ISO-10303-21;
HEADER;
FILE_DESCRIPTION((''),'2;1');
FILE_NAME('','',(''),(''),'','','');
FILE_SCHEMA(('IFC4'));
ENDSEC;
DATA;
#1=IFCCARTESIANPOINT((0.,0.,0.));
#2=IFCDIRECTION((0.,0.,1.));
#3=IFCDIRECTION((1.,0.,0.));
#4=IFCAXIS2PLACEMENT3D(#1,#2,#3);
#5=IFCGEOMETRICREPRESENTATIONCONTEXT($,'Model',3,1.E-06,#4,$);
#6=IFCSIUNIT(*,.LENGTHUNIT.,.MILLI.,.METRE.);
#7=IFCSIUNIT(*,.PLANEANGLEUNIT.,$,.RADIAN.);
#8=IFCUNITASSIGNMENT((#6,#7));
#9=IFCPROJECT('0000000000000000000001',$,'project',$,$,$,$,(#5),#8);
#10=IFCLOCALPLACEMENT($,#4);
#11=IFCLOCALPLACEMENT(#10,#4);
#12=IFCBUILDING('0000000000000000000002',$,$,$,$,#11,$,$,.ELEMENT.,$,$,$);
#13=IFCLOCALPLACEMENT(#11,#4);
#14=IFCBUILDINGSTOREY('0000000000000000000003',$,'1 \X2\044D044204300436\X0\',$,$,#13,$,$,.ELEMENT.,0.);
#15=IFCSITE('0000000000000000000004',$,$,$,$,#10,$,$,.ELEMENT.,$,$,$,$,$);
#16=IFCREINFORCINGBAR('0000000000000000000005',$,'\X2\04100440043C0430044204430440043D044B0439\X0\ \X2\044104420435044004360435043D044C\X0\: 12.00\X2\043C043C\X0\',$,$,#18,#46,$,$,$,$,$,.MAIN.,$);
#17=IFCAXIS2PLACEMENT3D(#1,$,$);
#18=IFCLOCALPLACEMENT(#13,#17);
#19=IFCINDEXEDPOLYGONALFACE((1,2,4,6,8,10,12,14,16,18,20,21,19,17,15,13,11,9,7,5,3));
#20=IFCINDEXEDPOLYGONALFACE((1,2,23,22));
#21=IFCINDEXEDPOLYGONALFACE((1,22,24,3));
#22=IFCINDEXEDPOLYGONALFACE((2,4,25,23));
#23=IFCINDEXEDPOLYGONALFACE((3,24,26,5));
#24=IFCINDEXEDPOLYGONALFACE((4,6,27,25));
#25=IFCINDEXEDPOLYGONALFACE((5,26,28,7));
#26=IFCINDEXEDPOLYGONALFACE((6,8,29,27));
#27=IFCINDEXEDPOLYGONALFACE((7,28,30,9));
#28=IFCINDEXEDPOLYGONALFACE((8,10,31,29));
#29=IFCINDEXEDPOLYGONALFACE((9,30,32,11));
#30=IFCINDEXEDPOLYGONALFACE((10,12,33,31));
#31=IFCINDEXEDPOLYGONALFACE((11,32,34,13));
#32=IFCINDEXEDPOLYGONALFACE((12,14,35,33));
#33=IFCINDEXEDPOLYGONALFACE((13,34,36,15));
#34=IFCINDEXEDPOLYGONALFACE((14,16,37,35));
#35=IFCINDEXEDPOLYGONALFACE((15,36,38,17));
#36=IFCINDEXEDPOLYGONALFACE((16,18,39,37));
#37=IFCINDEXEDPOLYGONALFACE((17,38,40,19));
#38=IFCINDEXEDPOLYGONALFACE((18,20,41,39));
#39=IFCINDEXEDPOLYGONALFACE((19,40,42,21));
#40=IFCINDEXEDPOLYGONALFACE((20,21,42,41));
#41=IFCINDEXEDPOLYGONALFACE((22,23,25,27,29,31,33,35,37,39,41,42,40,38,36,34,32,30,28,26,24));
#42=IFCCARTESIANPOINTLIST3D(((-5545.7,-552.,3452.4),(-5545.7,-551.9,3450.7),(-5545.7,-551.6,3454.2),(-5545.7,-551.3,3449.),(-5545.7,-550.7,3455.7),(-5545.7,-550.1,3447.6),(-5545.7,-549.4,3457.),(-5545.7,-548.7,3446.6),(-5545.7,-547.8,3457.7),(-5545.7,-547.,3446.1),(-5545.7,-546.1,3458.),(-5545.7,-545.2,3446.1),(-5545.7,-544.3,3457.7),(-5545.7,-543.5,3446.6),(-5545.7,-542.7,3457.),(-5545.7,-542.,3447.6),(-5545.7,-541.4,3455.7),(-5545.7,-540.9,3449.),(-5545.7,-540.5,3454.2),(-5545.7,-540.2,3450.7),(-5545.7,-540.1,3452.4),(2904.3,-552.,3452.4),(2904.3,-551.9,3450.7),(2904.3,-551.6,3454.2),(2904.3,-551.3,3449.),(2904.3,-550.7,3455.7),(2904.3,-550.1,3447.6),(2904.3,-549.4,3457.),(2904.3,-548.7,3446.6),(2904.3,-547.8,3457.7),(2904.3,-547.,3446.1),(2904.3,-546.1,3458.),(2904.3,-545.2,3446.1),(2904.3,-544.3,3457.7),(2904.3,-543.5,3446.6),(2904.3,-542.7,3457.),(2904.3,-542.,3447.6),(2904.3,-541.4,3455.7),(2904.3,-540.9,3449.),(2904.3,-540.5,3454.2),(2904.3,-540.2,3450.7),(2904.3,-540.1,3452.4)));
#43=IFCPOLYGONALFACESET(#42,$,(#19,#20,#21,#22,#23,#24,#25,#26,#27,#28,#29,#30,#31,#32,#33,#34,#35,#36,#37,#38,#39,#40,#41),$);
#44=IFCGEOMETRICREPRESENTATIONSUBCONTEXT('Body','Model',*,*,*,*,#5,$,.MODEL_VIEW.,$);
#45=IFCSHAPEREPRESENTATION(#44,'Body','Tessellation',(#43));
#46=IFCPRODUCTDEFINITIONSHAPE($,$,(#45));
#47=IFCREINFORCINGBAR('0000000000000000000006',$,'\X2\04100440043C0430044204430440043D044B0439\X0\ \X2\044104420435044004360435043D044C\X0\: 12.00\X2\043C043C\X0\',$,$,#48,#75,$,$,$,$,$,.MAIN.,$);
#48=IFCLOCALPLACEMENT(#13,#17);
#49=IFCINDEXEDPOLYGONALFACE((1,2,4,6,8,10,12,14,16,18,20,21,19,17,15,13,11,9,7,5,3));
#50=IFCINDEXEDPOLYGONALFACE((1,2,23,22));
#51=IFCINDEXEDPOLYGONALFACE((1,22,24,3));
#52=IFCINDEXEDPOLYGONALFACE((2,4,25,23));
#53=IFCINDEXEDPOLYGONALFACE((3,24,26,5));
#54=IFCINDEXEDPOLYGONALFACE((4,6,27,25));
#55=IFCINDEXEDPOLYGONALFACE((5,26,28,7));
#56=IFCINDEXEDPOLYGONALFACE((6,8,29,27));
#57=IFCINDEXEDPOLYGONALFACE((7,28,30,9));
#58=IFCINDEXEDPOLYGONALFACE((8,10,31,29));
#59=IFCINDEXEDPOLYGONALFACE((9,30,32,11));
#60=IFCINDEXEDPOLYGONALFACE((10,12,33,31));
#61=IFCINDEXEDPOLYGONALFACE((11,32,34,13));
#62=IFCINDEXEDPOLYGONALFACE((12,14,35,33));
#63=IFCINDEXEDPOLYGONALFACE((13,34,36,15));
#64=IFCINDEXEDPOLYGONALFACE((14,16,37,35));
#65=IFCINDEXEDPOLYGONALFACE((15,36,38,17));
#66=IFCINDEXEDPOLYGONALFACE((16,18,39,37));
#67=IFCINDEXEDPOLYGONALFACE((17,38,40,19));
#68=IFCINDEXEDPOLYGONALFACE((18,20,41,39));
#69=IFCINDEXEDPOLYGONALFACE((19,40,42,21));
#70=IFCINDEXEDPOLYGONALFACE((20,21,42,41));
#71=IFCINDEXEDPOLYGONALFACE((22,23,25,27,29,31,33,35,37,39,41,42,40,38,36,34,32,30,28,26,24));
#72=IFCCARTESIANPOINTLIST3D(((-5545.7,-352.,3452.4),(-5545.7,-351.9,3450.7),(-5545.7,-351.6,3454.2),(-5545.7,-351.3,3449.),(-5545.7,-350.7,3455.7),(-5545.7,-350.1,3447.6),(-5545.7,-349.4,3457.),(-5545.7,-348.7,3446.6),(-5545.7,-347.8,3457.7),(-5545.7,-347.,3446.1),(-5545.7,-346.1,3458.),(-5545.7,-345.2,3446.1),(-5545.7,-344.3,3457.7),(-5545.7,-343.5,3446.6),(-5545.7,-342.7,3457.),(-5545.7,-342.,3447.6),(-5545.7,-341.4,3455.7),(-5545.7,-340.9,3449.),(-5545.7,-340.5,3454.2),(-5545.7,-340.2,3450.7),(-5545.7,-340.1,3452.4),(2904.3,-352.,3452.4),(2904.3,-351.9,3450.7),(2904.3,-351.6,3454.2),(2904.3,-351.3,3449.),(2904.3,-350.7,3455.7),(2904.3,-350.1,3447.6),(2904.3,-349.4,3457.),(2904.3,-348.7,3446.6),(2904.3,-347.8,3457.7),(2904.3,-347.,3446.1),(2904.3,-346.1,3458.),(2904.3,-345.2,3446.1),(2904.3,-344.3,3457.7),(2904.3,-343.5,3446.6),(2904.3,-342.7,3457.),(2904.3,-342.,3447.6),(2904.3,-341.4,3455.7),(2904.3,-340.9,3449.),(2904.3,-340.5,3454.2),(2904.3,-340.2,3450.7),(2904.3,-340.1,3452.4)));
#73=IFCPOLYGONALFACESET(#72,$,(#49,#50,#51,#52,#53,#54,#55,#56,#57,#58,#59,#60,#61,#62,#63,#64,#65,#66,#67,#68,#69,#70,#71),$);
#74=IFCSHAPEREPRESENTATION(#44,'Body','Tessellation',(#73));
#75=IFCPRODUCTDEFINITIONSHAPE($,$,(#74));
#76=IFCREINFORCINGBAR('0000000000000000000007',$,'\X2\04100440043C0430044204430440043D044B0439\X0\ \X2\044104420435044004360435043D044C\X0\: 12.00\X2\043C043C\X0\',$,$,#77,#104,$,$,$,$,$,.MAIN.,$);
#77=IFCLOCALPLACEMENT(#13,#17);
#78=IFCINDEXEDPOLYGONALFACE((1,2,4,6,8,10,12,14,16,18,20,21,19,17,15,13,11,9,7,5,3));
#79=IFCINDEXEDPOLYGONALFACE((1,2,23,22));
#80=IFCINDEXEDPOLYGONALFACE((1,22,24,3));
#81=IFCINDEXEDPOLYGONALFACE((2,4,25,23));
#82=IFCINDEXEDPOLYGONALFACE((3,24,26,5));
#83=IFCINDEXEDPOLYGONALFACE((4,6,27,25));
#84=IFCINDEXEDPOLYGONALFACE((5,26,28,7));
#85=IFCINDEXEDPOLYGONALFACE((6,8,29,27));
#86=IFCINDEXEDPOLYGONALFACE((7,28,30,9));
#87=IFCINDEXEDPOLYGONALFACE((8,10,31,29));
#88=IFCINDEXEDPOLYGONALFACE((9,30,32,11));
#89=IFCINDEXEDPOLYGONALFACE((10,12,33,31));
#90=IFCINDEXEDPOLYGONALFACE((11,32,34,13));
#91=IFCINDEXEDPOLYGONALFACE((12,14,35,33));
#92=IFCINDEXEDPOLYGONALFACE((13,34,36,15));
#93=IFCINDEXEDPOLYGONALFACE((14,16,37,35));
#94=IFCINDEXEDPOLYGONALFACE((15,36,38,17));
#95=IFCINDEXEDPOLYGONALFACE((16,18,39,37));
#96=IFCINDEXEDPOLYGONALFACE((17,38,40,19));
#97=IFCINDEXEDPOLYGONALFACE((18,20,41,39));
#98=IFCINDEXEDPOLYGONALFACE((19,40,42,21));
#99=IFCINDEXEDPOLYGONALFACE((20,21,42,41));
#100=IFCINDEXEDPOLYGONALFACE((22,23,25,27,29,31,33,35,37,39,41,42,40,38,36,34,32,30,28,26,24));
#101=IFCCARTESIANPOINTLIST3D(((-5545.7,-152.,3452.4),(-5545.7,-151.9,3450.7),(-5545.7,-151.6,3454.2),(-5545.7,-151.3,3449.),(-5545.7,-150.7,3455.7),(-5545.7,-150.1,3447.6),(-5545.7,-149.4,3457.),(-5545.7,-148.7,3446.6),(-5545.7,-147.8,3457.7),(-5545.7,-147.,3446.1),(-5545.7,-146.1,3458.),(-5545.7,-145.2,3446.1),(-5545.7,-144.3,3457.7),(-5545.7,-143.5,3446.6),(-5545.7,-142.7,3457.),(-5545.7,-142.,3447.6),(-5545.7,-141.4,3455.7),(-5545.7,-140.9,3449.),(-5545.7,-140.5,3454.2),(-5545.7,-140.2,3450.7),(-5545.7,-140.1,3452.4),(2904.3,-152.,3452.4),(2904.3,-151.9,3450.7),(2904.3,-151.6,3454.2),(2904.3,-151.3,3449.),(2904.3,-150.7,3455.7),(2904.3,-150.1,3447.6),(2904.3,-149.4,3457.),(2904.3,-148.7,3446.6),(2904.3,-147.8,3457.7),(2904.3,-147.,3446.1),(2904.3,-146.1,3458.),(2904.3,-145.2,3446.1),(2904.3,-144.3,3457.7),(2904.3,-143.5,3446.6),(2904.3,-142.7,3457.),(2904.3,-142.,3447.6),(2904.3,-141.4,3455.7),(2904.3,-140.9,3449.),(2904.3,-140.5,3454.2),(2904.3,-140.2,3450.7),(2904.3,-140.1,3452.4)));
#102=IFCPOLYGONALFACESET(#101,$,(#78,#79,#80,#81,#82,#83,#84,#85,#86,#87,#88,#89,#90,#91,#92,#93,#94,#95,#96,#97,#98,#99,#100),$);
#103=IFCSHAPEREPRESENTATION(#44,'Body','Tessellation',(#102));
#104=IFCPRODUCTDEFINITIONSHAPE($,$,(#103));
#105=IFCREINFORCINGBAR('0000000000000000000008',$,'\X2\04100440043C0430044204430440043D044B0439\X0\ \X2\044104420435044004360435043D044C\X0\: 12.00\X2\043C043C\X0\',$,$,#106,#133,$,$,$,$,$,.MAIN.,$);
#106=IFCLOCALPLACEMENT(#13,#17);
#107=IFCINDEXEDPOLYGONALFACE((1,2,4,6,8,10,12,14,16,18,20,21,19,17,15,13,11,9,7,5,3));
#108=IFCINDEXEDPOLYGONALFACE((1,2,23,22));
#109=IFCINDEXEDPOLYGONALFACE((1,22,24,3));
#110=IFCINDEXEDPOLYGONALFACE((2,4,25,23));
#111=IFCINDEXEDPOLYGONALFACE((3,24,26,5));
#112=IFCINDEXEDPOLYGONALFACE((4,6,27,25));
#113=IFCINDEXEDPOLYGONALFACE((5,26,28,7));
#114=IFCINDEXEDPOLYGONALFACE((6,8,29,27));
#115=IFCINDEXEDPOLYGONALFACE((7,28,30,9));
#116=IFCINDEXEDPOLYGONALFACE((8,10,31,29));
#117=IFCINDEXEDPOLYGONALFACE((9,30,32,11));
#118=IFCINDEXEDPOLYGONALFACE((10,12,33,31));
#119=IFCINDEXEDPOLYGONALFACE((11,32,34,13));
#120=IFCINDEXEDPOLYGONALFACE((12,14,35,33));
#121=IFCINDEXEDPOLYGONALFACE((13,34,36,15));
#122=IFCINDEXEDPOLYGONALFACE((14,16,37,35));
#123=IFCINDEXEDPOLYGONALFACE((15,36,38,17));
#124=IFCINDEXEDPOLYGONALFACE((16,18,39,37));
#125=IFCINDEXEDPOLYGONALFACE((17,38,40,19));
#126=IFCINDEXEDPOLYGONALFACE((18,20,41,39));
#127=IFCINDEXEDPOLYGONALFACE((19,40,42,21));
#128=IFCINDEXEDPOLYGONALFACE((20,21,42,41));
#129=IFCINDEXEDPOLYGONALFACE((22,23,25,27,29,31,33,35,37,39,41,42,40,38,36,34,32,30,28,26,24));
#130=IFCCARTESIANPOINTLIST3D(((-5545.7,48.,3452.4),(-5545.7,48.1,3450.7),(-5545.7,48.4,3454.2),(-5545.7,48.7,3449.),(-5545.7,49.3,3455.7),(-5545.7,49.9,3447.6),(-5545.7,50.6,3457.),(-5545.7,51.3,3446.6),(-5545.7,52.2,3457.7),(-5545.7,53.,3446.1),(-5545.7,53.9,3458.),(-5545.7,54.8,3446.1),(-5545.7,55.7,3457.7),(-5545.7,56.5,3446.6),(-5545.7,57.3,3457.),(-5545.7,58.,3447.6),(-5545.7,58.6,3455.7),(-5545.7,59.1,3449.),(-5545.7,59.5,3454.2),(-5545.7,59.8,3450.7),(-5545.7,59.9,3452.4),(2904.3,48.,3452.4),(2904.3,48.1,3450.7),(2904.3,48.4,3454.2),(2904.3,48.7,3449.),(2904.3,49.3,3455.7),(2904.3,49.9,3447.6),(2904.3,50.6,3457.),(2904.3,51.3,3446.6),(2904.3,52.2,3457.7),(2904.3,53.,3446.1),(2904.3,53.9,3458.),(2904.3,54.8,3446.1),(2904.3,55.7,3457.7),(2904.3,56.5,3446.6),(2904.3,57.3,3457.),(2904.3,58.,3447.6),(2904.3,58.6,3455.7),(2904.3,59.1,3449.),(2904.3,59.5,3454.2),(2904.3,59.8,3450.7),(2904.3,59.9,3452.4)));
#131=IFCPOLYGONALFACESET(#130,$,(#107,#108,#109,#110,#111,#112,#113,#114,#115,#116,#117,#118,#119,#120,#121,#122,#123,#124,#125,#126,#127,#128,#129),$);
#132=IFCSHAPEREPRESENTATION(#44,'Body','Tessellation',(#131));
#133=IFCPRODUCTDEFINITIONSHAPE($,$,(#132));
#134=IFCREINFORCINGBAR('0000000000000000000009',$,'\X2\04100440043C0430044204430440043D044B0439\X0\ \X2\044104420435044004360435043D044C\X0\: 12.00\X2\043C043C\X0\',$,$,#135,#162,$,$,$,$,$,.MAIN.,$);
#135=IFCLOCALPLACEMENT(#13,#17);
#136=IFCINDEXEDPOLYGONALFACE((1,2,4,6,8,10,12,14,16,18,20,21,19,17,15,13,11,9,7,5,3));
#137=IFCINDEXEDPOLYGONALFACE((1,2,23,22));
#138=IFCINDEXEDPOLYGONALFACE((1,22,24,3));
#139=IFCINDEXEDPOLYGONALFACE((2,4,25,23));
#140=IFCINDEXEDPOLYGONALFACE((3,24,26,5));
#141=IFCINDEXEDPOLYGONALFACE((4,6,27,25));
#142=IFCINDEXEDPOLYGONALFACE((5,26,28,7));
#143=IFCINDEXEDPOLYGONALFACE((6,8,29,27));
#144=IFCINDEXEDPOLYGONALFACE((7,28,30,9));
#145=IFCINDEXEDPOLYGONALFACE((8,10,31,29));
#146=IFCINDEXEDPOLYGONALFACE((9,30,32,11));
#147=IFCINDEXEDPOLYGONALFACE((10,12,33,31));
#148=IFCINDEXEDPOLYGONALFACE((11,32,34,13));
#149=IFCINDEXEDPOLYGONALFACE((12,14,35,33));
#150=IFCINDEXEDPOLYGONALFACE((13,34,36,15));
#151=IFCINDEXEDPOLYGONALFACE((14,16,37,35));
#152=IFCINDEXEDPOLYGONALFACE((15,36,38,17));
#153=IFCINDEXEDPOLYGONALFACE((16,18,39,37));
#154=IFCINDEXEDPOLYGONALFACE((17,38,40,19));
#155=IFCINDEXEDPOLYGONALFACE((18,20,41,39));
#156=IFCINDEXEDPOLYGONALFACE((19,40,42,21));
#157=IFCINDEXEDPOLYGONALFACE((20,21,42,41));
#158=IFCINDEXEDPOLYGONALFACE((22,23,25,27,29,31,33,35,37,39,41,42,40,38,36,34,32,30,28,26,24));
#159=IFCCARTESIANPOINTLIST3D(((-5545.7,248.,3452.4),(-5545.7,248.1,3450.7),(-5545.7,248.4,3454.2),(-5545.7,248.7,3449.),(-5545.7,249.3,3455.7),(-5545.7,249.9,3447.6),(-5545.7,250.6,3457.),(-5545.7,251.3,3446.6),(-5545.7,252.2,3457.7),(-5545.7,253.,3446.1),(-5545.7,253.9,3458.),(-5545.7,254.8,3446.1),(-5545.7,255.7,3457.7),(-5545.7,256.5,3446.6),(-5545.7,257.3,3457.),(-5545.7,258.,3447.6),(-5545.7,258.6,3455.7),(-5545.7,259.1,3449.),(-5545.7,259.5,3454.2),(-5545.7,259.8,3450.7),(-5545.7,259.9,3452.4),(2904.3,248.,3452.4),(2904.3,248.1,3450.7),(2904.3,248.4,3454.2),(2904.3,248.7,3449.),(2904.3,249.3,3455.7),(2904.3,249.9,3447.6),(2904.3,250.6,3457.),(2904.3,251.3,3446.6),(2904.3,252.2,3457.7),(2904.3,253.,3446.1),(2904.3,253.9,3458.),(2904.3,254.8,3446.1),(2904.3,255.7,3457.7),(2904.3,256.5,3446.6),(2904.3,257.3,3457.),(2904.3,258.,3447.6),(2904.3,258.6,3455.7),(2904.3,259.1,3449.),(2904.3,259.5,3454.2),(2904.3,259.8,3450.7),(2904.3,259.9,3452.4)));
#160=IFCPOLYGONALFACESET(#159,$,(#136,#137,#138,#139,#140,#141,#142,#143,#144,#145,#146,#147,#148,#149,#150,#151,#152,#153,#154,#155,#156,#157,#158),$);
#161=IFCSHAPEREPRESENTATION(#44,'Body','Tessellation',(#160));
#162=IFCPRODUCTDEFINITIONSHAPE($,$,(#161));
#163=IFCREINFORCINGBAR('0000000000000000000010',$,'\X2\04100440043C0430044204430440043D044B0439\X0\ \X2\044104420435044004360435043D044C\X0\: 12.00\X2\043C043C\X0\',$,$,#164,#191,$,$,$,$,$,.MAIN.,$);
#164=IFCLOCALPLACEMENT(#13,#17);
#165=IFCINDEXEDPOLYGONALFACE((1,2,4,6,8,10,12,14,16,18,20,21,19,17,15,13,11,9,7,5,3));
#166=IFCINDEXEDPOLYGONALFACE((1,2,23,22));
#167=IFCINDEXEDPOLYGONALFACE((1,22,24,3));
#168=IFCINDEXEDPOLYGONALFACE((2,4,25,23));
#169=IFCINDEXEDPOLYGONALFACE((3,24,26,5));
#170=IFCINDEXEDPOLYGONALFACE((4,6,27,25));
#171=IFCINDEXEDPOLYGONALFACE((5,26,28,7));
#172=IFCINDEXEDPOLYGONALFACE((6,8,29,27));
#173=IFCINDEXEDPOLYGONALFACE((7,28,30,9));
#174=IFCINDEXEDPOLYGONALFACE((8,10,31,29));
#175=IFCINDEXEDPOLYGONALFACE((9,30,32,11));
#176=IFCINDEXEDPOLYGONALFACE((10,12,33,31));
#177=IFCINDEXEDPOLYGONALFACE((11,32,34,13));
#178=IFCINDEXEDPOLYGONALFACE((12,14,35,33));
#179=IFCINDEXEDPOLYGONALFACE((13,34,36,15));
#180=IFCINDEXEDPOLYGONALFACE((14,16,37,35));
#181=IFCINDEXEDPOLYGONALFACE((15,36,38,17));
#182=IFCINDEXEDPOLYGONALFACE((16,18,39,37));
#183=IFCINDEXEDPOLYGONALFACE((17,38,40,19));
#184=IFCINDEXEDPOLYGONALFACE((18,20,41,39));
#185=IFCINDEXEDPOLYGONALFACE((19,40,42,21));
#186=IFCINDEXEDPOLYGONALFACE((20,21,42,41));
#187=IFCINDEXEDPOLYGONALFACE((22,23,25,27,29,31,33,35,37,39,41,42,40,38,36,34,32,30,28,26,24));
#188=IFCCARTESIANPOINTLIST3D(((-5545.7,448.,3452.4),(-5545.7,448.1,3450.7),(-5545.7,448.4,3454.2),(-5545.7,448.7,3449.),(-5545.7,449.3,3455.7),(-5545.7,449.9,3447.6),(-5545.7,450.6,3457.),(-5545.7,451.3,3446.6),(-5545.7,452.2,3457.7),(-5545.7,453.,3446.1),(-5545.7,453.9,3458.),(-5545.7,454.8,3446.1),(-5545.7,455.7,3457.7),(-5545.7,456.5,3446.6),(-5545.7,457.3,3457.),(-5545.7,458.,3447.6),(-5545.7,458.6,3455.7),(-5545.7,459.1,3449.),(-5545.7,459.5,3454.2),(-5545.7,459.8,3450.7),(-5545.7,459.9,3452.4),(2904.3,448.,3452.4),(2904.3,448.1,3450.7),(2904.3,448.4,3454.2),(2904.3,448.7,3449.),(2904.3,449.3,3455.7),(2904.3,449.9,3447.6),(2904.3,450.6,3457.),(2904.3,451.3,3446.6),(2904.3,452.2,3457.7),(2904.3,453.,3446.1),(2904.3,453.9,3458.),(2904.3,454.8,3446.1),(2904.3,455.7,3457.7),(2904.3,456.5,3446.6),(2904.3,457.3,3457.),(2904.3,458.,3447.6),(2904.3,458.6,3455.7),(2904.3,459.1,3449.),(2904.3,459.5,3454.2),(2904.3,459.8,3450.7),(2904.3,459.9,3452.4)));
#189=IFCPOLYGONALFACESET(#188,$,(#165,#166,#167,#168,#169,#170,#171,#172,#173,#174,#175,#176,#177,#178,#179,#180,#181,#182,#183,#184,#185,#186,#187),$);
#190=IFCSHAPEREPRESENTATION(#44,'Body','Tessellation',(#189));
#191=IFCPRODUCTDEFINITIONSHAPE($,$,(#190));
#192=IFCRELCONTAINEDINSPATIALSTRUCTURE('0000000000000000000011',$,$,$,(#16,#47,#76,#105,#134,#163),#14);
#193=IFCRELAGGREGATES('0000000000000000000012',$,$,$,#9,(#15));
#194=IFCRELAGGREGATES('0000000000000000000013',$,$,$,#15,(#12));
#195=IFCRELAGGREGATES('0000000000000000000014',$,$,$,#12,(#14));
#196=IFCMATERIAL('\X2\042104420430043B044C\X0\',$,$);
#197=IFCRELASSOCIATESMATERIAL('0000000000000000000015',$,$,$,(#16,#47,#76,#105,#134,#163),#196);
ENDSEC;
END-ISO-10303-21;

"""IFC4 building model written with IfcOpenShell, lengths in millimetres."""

from ifc_helpers import new_model, entity, si_unit, origin_with_axes, place, context, subcontext, project, spatial, source, transform, mapped, material, element, save


model = new_model("IFC4")

# Units and contexts
model_context = context("Model", 3, precision=1e-06, world=origin_with_axes())
body_context = subcontext(model_context, "Body", "Model", "MODEL_VIEW")
ifc_project = project(units=[si_unit("LENGTHUNIT", "METRE", prefix="MILLI"), si_unit("PLANEANGLEUNIT", "RADIAN")], contexts=[model_context])

# Site, building, storey
site_placement = place(None, origin_with_axes())
site = spatial("IfcSite", under=ifc_project, at=site_placement, CompositionType="ELEMENT")
building_placement = place(site_placement, origin_with_axes())
building = spatial("IfcBuilding", under=site, at=building_placement, CompositionType="ELEMENT")
storey_placement = place(building_placement, origin_with_axes())
storey = spatial("IfcBuildingStorey", under=building, at=storey_placement, Name="1 этаж", CompositionType="ELEMENT", Elevation=0.0)

# Reinforcing bars
ifc_material_1 = material(Name="Сталь")
shared_shape_1 = source(origin_with_axes(), body_context, "Body", "AdvancedSweptSolid", [
    entity("IfcSweptDiskSolid", entity("IfcIndexedPolyCurve", entity("IfcCartesianPointList3D", [[0.0, 0.0, 0.0], [8450.0, 0.0, 0.0]]), [entity("IfcLineIndex", [1, 2])]), 6.0),
])
reinforcing_bar_1_placement = place(storey_placement, origin_with_axes())
element("IfcReinforcingBar", 1, at=reinforcing_bar_1_placement, inside=storey, material=ifc_material_1, Name="Арматурный стержень: 12.00мм", PredefinedType="MAIN", context=body_context, shape_type="MappedRepresentation", body=[
    mapped(shared_shape_1, transform((-5545.7, -546.1, 3452.0), x_axis=(1.0, 0.0, 0.0), y_axis=(0.0, 1.0, 0.0), z_axis=(0.0, 0.0, 1.0), scale=1.0)),
])
reinforcing_bar_2_placement = place(storey_placement, origin_with_axes())
element("IfcReinforcingBar", 2, at=reinforcing_bar_2_placement, inside=storey, material=ifc_material_1, Name="Арматурный стержень: 12.00мм", PredefinedType="MAIN", context=body_context, shape_type="MappedRepresentation", body=[
    mapped(shared_shape_1, transform((-5545.7, -346.1, 3452.0), x_axis=(1.0, 0.0, 0.0), y_axis=(0.0, 1.0, 0.0), z_axis=(0.0, 0.0, 1.0), scale=1.0)),
])
reinforcing_bar_3_placement = place(storey_placement, origin_with_axes())
element("IfcReinforcingBar", 3, at=reinforcing_bar_3_placement, inside=storey, material=ifc_material_1, Name="Арматурный стержень: 12.00мм", PredefinedType="MAIN", context=body_context, shape_type="MappedRepresentation", body=[
    mapped(shared_shape_1, transform((-5545.7, -146.1, 3452.0), x_axis=(1.0, 0.0, 0.0), y_axis=(0.0, 1.0, 0.0), z_axis=(0.0, 0.0, 1.0), scale=1.0)),
])
reinforcing_bar_4_placement = place(storey_placement, origin_with_axes())
element("IfcReinforcingBar", 4, at=reinforcing_bar_4_placement, inside=storey, material=ifc_material_1, Name="Арматурный стержень: 12.00мм", PredefinedType="MAIN", context=body_context, shape_type="MappedRepresentation", body=[
    mapped(shared_shape_1, transform((-5545.7, 53.9, 3452.0), x_axis=(1.0, 0.0, 0.0), y_axis=(0.0, 1.0, 0.0), z_axis=(0.0, 0.0, 1.0), scale=1.0)),
])
reinforcing_bar_5_placement = place(storey_placement, origin_with_axes())
element("IfcReinforcingBar", 5, at=reinforcing_bar_5_placement, inside=storey, material=ifc_material_1, Name="Арматурный стержень: 12.00мм", PredefinedType="MAIN", context=body_context, shape_type="MappedRepresentation", body=[
    mapped(shared_shape_1, transform((-5545.7, 253.9, 3452.0), x_axis=(1.0, 0.0, 0.0), y_axis=(0.0, 1.0, 0.0), z_axis=(0.0, 0.0, 1.0), scale=1.0)),
])
reinforcing_bar_6_placement = place(storey_placement, origin_with_axes())
element("IfcReinforcingBar", 6, at=reinforcing_bar_6_placement, inside=storey, material=ifc_material_1, Name="Арматурный стержень: 12.00мм", PredefinedType="MAIN", context=body_context, shape_type="MappedRepresentation", body=[
    mapped(shared_shape_1, transform((-5545.7, 453.9, 3452.0), x_axis=(1.0, 0.0, 0.0), y_axis=(0.0, 1.0, 0.0), z_axis=(0.0, 0.0, 1.0), scale=1.0)),
])

save(model, "model.ifc")
